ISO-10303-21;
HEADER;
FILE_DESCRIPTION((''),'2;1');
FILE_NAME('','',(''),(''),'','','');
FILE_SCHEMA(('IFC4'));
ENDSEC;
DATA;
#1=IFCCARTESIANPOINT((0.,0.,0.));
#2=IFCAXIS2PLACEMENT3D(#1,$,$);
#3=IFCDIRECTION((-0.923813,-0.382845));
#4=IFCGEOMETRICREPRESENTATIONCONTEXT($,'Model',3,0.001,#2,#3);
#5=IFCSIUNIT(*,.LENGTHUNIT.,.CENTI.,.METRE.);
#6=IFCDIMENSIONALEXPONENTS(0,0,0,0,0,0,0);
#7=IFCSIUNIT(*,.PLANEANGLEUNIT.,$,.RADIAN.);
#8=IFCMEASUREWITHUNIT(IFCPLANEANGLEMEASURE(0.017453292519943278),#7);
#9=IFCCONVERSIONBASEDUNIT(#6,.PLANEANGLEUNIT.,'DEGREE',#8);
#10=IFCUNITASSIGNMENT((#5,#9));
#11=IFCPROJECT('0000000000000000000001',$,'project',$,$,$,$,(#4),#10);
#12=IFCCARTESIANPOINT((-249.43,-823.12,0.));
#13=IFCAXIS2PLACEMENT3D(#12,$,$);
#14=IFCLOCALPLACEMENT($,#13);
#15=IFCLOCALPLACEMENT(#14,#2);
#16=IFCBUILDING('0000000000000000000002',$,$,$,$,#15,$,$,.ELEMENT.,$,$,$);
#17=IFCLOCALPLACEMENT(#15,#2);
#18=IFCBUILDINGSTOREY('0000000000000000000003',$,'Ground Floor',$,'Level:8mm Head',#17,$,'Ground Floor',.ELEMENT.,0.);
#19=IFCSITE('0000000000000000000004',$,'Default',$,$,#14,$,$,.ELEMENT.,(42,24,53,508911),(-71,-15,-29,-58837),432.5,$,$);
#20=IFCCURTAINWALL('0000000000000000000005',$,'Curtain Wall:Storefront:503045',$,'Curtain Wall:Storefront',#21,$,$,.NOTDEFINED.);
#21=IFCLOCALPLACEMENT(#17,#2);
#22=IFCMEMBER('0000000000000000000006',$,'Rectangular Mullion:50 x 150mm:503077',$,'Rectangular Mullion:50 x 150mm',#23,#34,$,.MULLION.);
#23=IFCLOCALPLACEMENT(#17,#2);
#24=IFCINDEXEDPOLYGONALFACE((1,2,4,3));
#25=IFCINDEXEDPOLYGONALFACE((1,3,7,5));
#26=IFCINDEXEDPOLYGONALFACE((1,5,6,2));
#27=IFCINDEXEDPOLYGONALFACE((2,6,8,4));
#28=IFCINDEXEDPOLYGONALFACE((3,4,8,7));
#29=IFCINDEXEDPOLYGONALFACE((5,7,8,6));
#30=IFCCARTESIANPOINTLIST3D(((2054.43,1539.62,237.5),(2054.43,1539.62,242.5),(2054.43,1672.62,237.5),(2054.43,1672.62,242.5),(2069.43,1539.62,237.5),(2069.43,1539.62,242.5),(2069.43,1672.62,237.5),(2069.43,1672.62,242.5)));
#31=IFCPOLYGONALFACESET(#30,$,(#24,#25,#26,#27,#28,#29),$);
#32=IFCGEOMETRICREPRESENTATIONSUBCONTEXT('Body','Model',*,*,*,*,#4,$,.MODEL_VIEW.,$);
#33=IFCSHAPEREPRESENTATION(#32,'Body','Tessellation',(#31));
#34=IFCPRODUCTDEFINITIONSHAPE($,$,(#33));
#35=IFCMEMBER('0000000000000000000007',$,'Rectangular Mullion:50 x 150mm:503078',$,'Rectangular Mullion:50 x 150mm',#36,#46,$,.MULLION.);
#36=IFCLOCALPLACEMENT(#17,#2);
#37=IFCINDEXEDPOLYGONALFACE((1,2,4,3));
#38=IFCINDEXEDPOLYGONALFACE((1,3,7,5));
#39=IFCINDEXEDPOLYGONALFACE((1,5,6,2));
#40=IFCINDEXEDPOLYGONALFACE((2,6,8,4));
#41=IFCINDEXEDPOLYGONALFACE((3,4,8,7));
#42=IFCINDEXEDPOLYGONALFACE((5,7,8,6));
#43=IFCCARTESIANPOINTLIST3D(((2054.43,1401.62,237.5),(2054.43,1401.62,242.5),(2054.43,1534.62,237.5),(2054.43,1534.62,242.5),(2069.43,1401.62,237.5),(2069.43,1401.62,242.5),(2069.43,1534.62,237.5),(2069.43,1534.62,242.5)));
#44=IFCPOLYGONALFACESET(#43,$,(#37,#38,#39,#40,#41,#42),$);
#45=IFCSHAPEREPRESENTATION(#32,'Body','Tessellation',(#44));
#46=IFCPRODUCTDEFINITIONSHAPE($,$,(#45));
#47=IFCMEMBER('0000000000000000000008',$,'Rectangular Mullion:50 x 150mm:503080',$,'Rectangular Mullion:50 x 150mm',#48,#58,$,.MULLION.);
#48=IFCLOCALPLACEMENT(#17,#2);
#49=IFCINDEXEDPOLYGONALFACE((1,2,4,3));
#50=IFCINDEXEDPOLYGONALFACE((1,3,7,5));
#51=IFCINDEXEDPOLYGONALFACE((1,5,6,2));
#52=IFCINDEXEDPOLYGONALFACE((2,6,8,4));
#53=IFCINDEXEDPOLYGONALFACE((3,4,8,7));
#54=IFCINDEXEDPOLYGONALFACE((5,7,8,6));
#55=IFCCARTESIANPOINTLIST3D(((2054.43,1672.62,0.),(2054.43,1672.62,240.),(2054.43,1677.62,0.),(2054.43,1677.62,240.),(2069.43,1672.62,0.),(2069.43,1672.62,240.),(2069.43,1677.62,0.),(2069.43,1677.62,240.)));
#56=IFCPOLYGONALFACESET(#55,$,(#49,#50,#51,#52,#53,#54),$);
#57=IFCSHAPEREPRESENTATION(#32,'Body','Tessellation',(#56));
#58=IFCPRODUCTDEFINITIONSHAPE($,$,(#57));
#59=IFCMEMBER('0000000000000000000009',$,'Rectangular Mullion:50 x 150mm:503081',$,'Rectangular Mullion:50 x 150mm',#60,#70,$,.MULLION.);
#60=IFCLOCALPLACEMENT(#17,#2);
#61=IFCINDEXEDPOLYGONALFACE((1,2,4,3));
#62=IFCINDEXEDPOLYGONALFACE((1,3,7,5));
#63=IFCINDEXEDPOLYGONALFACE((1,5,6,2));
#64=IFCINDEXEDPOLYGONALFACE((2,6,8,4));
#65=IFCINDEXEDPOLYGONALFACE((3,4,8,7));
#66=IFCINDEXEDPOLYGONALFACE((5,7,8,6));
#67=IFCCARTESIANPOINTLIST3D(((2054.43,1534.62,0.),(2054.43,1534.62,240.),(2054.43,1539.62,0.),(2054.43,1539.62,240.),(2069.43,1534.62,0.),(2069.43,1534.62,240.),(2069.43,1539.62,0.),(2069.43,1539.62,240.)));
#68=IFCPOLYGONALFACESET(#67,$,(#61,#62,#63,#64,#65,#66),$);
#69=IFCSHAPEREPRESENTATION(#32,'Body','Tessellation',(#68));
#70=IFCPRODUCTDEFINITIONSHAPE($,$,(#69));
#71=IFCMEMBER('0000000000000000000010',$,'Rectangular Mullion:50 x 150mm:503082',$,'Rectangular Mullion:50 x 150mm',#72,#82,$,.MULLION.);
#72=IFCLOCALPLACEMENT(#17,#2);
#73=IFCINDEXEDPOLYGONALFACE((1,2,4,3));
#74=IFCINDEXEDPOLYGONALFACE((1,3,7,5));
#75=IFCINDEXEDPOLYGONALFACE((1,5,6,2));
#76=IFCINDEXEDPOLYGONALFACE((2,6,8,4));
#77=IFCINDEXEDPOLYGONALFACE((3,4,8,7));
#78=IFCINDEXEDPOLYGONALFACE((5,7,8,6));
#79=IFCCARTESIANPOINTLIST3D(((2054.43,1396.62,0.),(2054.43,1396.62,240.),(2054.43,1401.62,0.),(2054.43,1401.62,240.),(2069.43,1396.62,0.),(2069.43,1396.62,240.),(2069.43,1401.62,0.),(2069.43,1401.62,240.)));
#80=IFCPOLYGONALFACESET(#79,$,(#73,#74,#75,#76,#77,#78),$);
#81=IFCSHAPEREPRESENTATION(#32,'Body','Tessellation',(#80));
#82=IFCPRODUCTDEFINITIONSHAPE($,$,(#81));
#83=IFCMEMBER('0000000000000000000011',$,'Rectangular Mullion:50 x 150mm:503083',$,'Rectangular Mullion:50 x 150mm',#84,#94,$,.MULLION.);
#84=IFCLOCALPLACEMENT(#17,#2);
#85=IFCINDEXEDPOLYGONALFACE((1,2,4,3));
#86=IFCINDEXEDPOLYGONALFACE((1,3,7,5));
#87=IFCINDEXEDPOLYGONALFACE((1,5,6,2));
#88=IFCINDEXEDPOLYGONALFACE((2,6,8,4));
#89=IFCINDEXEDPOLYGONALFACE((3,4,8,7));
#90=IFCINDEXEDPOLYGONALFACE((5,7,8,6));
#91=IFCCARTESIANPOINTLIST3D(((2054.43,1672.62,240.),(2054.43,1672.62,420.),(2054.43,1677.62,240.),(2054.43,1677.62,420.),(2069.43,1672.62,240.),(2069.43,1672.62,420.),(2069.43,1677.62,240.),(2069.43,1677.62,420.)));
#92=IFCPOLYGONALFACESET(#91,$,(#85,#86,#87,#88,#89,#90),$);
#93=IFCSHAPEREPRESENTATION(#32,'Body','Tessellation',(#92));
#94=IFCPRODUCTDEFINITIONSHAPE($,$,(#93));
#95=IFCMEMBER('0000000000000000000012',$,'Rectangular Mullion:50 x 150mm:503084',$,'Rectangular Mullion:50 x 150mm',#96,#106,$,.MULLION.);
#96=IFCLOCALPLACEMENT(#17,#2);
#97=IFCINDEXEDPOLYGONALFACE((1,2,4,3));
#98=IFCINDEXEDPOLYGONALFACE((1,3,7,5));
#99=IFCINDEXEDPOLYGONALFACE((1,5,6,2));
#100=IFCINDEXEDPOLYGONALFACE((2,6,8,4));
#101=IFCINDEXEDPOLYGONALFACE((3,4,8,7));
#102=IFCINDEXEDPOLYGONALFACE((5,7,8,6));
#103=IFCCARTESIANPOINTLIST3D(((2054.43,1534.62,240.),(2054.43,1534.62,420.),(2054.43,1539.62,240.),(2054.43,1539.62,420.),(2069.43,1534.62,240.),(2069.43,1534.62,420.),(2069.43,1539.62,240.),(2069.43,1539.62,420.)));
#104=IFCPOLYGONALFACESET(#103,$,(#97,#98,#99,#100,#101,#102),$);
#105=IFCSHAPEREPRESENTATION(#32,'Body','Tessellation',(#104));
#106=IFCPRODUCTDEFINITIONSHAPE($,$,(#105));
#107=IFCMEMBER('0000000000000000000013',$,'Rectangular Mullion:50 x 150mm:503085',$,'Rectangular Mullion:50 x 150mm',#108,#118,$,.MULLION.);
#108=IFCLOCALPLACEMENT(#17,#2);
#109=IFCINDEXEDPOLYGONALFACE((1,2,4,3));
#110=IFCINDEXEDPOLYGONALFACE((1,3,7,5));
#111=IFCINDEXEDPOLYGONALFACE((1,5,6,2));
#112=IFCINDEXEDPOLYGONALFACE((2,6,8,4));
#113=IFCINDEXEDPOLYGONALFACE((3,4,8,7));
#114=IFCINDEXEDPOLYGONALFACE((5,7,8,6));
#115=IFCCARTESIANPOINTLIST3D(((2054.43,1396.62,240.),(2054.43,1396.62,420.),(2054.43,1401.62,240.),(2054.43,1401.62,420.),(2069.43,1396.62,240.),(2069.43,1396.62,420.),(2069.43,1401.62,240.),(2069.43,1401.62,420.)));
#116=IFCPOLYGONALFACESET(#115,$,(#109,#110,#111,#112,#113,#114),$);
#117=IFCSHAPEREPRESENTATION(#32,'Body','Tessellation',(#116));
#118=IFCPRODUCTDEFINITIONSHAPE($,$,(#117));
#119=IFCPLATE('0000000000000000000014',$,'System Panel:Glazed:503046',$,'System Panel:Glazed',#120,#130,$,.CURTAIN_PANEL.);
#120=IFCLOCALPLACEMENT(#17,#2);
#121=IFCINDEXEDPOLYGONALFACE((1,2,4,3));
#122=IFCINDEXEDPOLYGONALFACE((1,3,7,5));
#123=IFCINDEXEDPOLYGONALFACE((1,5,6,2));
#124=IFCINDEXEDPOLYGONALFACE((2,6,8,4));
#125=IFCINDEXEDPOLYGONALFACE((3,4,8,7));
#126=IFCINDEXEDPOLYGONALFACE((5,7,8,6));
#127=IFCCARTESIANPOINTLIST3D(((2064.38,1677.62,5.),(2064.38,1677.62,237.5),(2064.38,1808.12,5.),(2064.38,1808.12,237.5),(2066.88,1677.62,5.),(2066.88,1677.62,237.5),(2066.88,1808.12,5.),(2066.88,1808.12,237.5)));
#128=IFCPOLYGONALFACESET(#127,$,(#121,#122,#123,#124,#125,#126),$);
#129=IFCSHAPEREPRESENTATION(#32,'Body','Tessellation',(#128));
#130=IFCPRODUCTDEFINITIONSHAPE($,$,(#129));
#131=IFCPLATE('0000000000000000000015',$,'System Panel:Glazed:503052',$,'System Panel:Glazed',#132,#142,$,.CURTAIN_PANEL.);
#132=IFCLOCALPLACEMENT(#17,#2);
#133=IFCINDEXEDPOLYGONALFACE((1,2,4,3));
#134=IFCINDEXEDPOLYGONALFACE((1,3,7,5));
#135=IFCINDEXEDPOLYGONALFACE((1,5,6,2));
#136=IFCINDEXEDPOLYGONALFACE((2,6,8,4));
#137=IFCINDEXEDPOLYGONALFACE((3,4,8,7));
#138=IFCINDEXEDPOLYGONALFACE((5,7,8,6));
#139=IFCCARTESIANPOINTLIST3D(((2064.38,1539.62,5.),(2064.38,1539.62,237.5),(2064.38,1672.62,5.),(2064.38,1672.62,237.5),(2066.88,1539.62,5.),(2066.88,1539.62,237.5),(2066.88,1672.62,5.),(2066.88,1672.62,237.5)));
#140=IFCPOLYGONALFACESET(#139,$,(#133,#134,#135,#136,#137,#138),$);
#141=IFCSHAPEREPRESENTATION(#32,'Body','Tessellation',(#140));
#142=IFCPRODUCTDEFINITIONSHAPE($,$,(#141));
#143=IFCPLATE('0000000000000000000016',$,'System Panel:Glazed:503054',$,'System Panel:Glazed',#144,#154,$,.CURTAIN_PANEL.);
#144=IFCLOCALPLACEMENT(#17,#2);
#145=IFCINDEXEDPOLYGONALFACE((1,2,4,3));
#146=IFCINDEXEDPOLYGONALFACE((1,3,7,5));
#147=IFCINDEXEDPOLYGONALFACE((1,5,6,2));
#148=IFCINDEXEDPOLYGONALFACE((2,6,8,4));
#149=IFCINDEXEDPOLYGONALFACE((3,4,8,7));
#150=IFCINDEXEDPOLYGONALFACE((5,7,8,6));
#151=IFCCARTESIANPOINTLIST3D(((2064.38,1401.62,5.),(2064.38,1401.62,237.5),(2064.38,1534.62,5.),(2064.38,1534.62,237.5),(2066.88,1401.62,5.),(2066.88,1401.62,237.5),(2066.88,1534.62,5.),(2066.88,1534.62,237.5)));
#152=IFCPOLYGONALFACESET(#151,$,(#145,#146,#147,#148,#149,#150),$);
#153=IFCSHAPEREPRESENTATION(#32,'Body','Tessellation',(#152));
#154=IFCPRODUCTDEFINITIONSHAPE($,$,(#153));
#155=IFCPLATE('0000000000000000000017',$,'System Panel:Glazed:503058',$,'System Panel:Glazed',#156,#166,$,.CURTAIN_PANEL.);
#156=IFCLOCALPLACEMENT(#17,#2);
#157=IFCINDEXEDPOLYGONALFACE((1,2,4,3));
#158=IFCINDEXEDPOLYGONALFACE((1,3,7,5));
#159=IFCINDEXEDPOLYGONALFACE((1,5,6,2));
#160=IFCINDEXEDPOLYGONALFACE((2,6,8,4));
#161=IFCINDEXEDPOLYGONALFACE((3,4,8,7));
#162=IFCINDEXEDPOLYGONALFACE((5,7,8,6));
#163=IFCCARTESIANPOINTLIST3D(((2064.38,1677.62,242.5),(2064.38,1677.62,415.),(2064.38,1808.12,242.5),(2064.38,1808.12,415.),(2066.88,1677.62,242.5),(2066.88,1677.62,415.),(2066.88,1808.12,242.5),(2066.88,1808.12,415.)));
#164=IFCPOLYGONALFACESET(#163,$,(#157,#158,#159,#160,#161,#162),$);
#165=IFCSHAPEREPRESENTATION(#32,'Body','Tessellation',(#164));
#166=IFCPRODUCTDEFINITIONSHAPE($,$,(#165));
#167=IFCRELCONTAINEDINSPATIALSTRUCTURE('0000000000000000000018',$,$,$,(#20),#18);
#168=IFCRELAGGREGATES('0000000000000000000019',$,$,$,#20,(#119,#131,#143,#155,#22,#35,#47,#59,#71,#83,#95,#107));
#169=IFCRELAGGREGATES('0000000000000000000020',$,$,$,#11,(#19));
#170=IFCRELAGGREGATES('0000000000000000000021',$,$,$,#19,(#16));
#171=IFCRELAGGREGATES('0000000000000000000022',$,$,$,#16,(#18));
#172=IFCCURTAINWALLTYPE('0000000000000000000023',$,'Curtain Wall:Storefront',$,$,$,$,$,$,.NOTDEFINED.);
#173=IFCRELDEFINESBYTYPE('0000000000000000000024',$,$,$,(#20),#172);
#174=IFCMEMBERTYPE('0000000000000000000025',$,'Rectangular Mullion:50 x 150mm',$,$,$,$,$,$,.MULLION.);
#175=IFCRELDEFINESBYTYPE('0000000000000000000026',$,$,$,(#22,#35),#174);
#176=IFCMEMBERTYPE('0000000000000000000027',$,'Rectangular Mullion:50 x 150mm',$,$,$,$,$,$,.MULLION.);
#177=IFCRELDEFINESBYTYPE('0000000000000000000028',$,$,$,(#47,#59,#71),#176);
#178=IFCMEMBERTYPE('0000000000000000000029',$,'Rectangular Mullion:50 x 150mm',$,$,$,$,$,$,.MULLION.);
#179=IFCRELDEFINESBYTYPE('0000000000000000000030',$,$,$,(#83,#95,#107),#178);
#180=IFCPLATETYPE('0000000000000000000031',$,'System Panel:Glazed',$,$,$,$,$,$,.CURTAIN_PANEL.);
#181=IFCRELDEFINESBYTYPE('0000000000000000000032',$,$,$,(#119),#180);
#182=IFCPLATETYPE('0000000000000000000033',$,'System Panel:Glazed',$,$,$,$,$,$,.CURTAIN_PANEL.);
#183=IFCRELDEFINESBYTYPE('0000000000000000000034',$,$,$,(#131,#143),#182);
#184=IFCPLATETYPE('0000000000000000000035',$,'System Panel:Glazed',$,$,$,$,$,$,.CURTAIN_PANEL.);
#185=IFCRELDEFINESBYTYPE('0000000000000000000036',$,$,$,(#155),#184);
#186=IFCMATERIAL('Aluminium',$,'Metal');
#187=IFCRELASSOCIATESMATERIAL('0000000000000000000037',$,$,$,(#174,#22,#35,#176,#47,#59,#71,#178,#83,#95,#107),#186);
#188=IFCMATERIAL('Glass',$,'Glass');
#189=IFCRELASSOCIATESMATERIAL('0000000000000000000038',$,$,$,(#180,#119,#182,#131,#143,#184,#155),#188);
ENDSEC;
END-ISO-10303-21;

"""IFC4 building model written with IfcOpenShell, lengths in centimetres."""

from ifc_helpers import new_model, entity, si_unit, converted_unit, direction, frame, origin, place, context, subcontext, project, spatial, indexed_curve, outline, extrude, source, transform, mapped, material, type_object, type_shapes, element, aggregate, save


model = new_model("IFC4")

# Units and contexts
model_context = context("Model", 3, precision=0.001, world=origin(), true_north=direction((-0.923813, -0.382845)))
body_context = subcontext(model_context, "Body", "Model", "MODEL_VIEW")
ifc_project = project(units=[si_unit("LENGTHUNIT", "METRE", prefix="CENTI"), converted_unit("PLANEANGLEUNIT", "DEGREE", entity("IfcPlaneAngleMeasure", 0.017453292519943278), si_unit("PLANEANGLEUNIT", "RADIAN"), dimensions=[0, 0, 0, 0, 0, 0, 0])], contexts=[model_context])

# Site, building, storey
site_placement = place(None, frame((-249.43, -823.12, 0.0)))
site = spatial("IfcSite", under=ifc_project, at=site_placement, Name="Default", CompositionType="ELEMENT", RefLatitude=(42, 24, 53, 508911), RefLongitude=(-71, -15, -29, -58837), RefElevation=432.5)
building_placement = place(site_placement, origin())
building = spatial("IfcBuilding", under=site, at=building_placement, CompositionType="ELEMENT")
storey_placement = place(building_placement, origin())
storey = spatial("IfcBuildingStorey", under=building, at=storey_placement, Name="Ground Floor", ObjectType="Level:8mm Head", LongName="Ground Floor", CompositionType="ELEMENT", Elevation=0.0)

# Curtain wall, members, plates
curtain_wall_type = type_object("IfcCurtainWallType", Name="Curtain Wall:Storefront", PredefinedType="NOTDEFINED")
curtain_wall_placement = place(storey_placement, origin())
curtain_wall = element("IfcCurtainWall", 1, at=curtain_wall_placement, inside=storey, type_object=curtain_wall_type, Name="Curtain Wall:Storefront:503045", ObjectType="Curtain Wall:Storefront", PredefinedType="NOTDEFINED")
ifc_material_1 = material(Name="Aluminium", Category="Metal")
member_type_1 = type_object("IfcMemberType", Name="Rectangular Mullion:50 x 150mm", PredefinedType="MULLION", material=ifc_material_1)
shared_shape_1 = source(origin(), body_context, "Body", "SweptSolid", [
    extrude(outline(indexed_curve([(-2.5, -7.5), (2.5, -7.5), (2.5, 7.5), (-2.5, 7.5), (-2.5, -7.5)], self_intersect=False)), frame((0.0, 0.0, -133.0), z_axis=(0.0, 0.0, 1.0), x_axis=(-1.0, 0.0, 0.0)), (0.0, 0.0, 1.0), 133.0),
])
type_shapes(member_type_1, [shared_shape_1])
member_1_placement = place(curtain_wall_placement, frame((2061.93, 1539.62, 240.0), z_axis=(0.0, -1.0, 0.0), x_axis=(0.0, 0.0, 1.0)))
member_1 = element("IfcMember", 2, at=member_1_placement, type_object=member_type_1, material=ifc_material_1, Name="Rectangular Mullion:50 x 150mm:503077", ObjectType="Rectangular Mullion:50 x 150mm", PredefinedType="MULLION", context=body_context, shape_type="MappedRepresentation", body=[
    mapped(shared_shape_1, transform((0.0, 0.0, 0.0), scale=1.0)),
])
member_2_placement = place(curtain_wall_placement, frame((2061.93, 1401.62, 240.0), z_axis=(0.0, -1.0, 0.0), x_axis=(0.0, 0.0, 1.0)))
member_2 = element("IfcMember", 3, at=member_2_placement, type_object=member_type_1, material=ifc_material_1, Name="Rectangular Mullion:50 x 150mm:503078", ObjectType="Rectangular Mullion:50 x 150mm", PredefinedType="MULLION", context=body_context, shape_type="MappedRepresentation", body=[
    mapped(shared_shape_1, transform((0.0, 0.0, 0.0), scale=1.0)),
])
member_type_2 = type_object("IfcMemberType", Name="Rectangular Mullion:50 x 150mm", PredefinedType="MULLION", material=ifc_material_1)
shared_shape_2 = source(origin(), body_context, "Body", "SweptSolid", [
    extrude(outline(indexed_curve([(-2.5, -7.5), (2.5, -7.5), (2.5, 7.5), (-2.5, 7.5), (-2.5, -7.5)], self_intersect=False)), frame((0.0, 0.0, -240.0), z_axis=(0.0, 0.0, 1.0), x_axis=(-1.0, 0.0, 0.0)), (0.0, 0.0, 1.0), 240.0),
])
type_shapes(member_type_2, [shared_shape_2])
member_3_placement = place(curtain_wall_placement, frame((2061.93, 1675.12, 0.0), z_axis=(0.0, 0.0, -1.0), x_axis=(0.0, -1.0, 0.0)))
member_3 = element("IfcMember", 4, at=member_3_placement, type_object=member_type_2, material=ifc_material_1, Name="Rectangular Mullion:50 x 150mm:503080", ObjectType="Rectangular Mullion:50 x 150mm", PredefinedType="MULLION", context=body_context, shape_type="MappedRepresentation", body=[
    mapped(shared_shape_2, transform((0.0, 0.0, 0.0), scale=1.0)),
])
member_4_placement = place(curtain_wall_placement, frame((2061.93, 1537.12, 0.0), z_axis=(0.0, 0.0, -1.0), x_axis=(0.0, -1.0, 0.0)))
member_4 = element("IfcMember", 5, at=member_4_placement, type_object=member_type_2, material=ifc_material_1, Name="Rectangular Mullion:50 x 150mm:503081", ObjectType="Rectangular Mullion:50 x 150mm", PredefinedType="MULLION", context=body_context, shape_type="MappedRepresentation", body=[
    mapped(shared_shape_2, transform((0.0, 0.0, 0.0), scale=1.0)),
])
member_5_placement = place(curtain_wall_placement, frame((2061.93, 1399.12, 0.0), z_axis=(0.0, 0.0, -1.0), x_axis=(0.0, -1.0, 0.0)))
member_5 = element("IfcMember", 6, at=member_5_placement, type_object=member_type_2, material=ifc_material_1, Name="Rectangular Mullion:50 x 150mm:503082", ObjectType="Rectangular Mullion:50 x 150mm", PredefinedType="MULLION", context=body_context, shape_type="MappedRepresentation", body=[
    mapped(shared_shape_2, transform((0.0, 0.0, 0.0), scale=1.0)),
])
member_type_3 = type_object("IfcMemberType", Name="Rectangular Mullion:50 x 150mm", PredefinedType="MULLION", material=ifc_material_1)
shared_shape_3 = source(origin(), body_context, "Body", "SweptSolid", [
    extrude(outline(indexed_curve([(-2.5, -7.5), (2.5, -7.5), (2.5, 7.5), (-2.5, 7.5), (-2.5, -7.5)], self_intersect=False)), frame((0.0, 0.0, -180.0), z_axis=(0.0, 0.0, 1.0), x_axis=(-1.0, 0.0, 0.0)), (0.0, 0.0, 1.0), 180.0),
])
type_shapes(member_type_3, [shared_shape_3])
member_6_placement = place(curtain_wall_placement, frame((2061.93, 1675.12, 240.0), z_axis=(0.0, 0.0, -1.0), x_axis=(0.0, -1.0, 0.0)))
member_6 = element("IfcMember", 7, at=member_6_placement, type_object=member_type_3, material=ifc_material_1, Name="Rectangular Mullion:50 x 150mm:503083", ObjectType="Rectangular Mullion:50 x 150mm", PredefinedType="MULLION", context=body_context, shape_type="MappedRepresentation", body=[
    mapped(shared_shape_3, transform((0.0, 0.0, 0.0), scale=1.0)),
])
member_7_placement = place(curtain_wall_placement, frame((2061.93, 1537.12, 240.0), z_axis=(0.0, 0.0, -1.0), x_axis=(0.0, -1.0, 0.0)))
member_7 = element("IfcMember", 8, at=member_7_placement, type_object=member_type_3, material=ifc_material_1, Name="Rectangular Mullion:50 x 150mm:503084", ObjectType="Rectangular Mullion:50 x 150mm", PredefinedType="MULLION", context=body_context, shape_type="MappedRepresentation", body=[
    mapped(shared_shape_3, transform((0.0, 0.0, 0.0), scale=1.0)),
])
member_8_placement = place(curtain_wall_placement, frame((2061.93, 1399.12, 240.0), z_axis=(0.0, 0.0, -1.0), x_axis=(0.0, -1.0, 0.0)))
member_8 = element("IfcMember", 9, at=member_8_placement, type_object=member_type_3, material=ifc_material_1, Name="Rectangular Mullion:50 x 150mm:503085", ObjectType="Rectangular Mullion:50 x 150mm", PredefinedType="MULLION", context=body_context, shape_type="MappedRepresentation", body=[
    mapped(shared_shape_3, transform((0.0, 0.0, 0.0), scale=1.0)),
])
ifc_material_2 = material(Name="Glass", Category="Glass")
plate_type_1 = type_object("IfcPlateType", Name="System Panel:Glazed", PredefinedType="CURTAIN_PANEL", material=ifc_material_2)
shared_shape_4 = source(origin(), body_context, "Body", "SweptSolid", [
    extrude(outline(indexed_curve([(-1.25, -65.25), (1.25, -65.25), (1.25, 65.25), (-1.25, 65.25), (-1.25, -65.25)], self_intersect=False)), frame((0.0, 3.7, 0.0), z_axis=(0.0, 0.0, 1.0), x_axis=(0.0, 1.0, 0.0)), (0.0, 0.0, 1.0), 232.5),
])
type_shapes(plate_type_1, [shared_shape_4])
plate_1_placement = place(curtain_wall_placement, frame((2061.93, 1742.87, 5.0), z_axis=(0.0, 0.0, 1.0), x_axis=(0.0, -1.0, 0.0)))
plate_1 = element("IfcPlate", 10, at=plate_1_placement, type_object=plate_type_1, material=ifc_material_2, Name="System Panel:Glazed:503046", ObjectType="System Panel:Glazed", PredefinedType="CURTAIN_PANEL", context=body_context, shape_type="MappedRepresentation", body=[
    mapped(shared_shape_4, transform((0.0, 0.0, 0.0), scale=1.0)),
])
plate_type_2 = type_object("IfcPlateType", Name="System Panel:Glazed", PredefinedType="CURTAIN_PANEL", material=ifc_material_2)
shared_shape_5 = source(origin(), body_context, "Body", "SweptSolid", [
    extrude(outline(indexed_curve([(-1.25, -66.5), (1.25, -66.5), (1.25, 66.5), (-1.25, 66.5), (-1.25, -66.5)], self_intersect=False)), frame((0.0, 3.7, 0.0), z_axis=(0.0, 0.0, 1.0), x_axis=(0.0, 1.0, 0.0)), (0.0, 0.0, 1.0), 232.5),
])
type_shapes(plate_type_2, [shared_shape_5])
plate_2_placement = place(curtain_wall_placement, frame((2061.93, 1606.12, 5.0), z_axis=(0.0, 0.0, 1.0), x_axis=(0.0, -1.0, 0.0)))
plate_2 = element("IfcPlate", 11, at=plate_2_placement, type_object=plate_type_2, material=ifc_material_2, Name="System Panel:Glazed:503052", ObjectType="System Panel:Glazed", PredefinedType="CURTAIN_PANEL", context=body_context, shape_type="MappedRepresentation", body=[
    mapped(shared_shape_5, transform((0.0, 0.0, 0.0), scale=1.0)),
])
plate_3_placement = place(curtain_wall_placement, frame((2061.93, 1468.12, 5.0), z_axis=(0.0, 0.0, 1.0), x_axis=(0.0, -1.0, 0.0)))
plate_3 = element("IfcPlate", 12, at=plate_3_placement, type_object=plate_type_2, material=ifc_material_2, Name="System Panel:Glazed:503054", ObjectType="System Panel:Glazed", PredefinedType="CURTAIN_PANEL", context=body_context, shape_type="MappedRepresentation", body=[
    mapped(shared_shape_5, transform((0.0, 0.0, 0.0), scale=1.0)),
])
plate_type_3 = type_object("IfcPlateType", Name="System Panel:Glazed", PredefinedType="CURTAIN_PANEL", material=ifc_material_2)
shared_shape_6 = source(origin(), body_context, "Body", "SweptSolid", [
    extrude(outline(indexed_curve([(-1.25, -65.25), (1.25, -65.25), (1.25, 65.25), (-1.25, 65.25), (-1.25, -65.25)], self_intersect=False)), frame((0.0, 3.7, 0.0), z_axis=(0.0, 0.0, 1.0), x_axis=(0.0, 1.0, 0.0)), (0.0, 0.0, 1.0), 172.5),
])
type_shapes(plate_type_3, [shared_shape_6])
plate_4_placement = place(curtain_wall_placement, frame((2061.93, 1742.87, 242.5), z_axis=(0.0, 0.0, 1.0), x_axis=(0.0, -1.0, 0.0)))
plate_4 = element("IfcPlate", 13, at=plate_4_placement, type_object=plate_type_3, material=ifc_material_2, Name="System Panel:Glazed:503058", ObjectType="System Panel:Glazed", PredefinedType="CURTAIN_PANEL", context=body_context, shape_type="MappedRepresentation", body=[
    mapped(shared_shape_6, transform((0.0, 0.0, 0.0), scale=1.0)),
])
aggregate(curtain_wall, [plate_1, plate_2, plate_3, plate_4, member_1, member_2, member_3, member_4, member_5, member_6, member_7, member_8])

save(model, "model.ifc")
